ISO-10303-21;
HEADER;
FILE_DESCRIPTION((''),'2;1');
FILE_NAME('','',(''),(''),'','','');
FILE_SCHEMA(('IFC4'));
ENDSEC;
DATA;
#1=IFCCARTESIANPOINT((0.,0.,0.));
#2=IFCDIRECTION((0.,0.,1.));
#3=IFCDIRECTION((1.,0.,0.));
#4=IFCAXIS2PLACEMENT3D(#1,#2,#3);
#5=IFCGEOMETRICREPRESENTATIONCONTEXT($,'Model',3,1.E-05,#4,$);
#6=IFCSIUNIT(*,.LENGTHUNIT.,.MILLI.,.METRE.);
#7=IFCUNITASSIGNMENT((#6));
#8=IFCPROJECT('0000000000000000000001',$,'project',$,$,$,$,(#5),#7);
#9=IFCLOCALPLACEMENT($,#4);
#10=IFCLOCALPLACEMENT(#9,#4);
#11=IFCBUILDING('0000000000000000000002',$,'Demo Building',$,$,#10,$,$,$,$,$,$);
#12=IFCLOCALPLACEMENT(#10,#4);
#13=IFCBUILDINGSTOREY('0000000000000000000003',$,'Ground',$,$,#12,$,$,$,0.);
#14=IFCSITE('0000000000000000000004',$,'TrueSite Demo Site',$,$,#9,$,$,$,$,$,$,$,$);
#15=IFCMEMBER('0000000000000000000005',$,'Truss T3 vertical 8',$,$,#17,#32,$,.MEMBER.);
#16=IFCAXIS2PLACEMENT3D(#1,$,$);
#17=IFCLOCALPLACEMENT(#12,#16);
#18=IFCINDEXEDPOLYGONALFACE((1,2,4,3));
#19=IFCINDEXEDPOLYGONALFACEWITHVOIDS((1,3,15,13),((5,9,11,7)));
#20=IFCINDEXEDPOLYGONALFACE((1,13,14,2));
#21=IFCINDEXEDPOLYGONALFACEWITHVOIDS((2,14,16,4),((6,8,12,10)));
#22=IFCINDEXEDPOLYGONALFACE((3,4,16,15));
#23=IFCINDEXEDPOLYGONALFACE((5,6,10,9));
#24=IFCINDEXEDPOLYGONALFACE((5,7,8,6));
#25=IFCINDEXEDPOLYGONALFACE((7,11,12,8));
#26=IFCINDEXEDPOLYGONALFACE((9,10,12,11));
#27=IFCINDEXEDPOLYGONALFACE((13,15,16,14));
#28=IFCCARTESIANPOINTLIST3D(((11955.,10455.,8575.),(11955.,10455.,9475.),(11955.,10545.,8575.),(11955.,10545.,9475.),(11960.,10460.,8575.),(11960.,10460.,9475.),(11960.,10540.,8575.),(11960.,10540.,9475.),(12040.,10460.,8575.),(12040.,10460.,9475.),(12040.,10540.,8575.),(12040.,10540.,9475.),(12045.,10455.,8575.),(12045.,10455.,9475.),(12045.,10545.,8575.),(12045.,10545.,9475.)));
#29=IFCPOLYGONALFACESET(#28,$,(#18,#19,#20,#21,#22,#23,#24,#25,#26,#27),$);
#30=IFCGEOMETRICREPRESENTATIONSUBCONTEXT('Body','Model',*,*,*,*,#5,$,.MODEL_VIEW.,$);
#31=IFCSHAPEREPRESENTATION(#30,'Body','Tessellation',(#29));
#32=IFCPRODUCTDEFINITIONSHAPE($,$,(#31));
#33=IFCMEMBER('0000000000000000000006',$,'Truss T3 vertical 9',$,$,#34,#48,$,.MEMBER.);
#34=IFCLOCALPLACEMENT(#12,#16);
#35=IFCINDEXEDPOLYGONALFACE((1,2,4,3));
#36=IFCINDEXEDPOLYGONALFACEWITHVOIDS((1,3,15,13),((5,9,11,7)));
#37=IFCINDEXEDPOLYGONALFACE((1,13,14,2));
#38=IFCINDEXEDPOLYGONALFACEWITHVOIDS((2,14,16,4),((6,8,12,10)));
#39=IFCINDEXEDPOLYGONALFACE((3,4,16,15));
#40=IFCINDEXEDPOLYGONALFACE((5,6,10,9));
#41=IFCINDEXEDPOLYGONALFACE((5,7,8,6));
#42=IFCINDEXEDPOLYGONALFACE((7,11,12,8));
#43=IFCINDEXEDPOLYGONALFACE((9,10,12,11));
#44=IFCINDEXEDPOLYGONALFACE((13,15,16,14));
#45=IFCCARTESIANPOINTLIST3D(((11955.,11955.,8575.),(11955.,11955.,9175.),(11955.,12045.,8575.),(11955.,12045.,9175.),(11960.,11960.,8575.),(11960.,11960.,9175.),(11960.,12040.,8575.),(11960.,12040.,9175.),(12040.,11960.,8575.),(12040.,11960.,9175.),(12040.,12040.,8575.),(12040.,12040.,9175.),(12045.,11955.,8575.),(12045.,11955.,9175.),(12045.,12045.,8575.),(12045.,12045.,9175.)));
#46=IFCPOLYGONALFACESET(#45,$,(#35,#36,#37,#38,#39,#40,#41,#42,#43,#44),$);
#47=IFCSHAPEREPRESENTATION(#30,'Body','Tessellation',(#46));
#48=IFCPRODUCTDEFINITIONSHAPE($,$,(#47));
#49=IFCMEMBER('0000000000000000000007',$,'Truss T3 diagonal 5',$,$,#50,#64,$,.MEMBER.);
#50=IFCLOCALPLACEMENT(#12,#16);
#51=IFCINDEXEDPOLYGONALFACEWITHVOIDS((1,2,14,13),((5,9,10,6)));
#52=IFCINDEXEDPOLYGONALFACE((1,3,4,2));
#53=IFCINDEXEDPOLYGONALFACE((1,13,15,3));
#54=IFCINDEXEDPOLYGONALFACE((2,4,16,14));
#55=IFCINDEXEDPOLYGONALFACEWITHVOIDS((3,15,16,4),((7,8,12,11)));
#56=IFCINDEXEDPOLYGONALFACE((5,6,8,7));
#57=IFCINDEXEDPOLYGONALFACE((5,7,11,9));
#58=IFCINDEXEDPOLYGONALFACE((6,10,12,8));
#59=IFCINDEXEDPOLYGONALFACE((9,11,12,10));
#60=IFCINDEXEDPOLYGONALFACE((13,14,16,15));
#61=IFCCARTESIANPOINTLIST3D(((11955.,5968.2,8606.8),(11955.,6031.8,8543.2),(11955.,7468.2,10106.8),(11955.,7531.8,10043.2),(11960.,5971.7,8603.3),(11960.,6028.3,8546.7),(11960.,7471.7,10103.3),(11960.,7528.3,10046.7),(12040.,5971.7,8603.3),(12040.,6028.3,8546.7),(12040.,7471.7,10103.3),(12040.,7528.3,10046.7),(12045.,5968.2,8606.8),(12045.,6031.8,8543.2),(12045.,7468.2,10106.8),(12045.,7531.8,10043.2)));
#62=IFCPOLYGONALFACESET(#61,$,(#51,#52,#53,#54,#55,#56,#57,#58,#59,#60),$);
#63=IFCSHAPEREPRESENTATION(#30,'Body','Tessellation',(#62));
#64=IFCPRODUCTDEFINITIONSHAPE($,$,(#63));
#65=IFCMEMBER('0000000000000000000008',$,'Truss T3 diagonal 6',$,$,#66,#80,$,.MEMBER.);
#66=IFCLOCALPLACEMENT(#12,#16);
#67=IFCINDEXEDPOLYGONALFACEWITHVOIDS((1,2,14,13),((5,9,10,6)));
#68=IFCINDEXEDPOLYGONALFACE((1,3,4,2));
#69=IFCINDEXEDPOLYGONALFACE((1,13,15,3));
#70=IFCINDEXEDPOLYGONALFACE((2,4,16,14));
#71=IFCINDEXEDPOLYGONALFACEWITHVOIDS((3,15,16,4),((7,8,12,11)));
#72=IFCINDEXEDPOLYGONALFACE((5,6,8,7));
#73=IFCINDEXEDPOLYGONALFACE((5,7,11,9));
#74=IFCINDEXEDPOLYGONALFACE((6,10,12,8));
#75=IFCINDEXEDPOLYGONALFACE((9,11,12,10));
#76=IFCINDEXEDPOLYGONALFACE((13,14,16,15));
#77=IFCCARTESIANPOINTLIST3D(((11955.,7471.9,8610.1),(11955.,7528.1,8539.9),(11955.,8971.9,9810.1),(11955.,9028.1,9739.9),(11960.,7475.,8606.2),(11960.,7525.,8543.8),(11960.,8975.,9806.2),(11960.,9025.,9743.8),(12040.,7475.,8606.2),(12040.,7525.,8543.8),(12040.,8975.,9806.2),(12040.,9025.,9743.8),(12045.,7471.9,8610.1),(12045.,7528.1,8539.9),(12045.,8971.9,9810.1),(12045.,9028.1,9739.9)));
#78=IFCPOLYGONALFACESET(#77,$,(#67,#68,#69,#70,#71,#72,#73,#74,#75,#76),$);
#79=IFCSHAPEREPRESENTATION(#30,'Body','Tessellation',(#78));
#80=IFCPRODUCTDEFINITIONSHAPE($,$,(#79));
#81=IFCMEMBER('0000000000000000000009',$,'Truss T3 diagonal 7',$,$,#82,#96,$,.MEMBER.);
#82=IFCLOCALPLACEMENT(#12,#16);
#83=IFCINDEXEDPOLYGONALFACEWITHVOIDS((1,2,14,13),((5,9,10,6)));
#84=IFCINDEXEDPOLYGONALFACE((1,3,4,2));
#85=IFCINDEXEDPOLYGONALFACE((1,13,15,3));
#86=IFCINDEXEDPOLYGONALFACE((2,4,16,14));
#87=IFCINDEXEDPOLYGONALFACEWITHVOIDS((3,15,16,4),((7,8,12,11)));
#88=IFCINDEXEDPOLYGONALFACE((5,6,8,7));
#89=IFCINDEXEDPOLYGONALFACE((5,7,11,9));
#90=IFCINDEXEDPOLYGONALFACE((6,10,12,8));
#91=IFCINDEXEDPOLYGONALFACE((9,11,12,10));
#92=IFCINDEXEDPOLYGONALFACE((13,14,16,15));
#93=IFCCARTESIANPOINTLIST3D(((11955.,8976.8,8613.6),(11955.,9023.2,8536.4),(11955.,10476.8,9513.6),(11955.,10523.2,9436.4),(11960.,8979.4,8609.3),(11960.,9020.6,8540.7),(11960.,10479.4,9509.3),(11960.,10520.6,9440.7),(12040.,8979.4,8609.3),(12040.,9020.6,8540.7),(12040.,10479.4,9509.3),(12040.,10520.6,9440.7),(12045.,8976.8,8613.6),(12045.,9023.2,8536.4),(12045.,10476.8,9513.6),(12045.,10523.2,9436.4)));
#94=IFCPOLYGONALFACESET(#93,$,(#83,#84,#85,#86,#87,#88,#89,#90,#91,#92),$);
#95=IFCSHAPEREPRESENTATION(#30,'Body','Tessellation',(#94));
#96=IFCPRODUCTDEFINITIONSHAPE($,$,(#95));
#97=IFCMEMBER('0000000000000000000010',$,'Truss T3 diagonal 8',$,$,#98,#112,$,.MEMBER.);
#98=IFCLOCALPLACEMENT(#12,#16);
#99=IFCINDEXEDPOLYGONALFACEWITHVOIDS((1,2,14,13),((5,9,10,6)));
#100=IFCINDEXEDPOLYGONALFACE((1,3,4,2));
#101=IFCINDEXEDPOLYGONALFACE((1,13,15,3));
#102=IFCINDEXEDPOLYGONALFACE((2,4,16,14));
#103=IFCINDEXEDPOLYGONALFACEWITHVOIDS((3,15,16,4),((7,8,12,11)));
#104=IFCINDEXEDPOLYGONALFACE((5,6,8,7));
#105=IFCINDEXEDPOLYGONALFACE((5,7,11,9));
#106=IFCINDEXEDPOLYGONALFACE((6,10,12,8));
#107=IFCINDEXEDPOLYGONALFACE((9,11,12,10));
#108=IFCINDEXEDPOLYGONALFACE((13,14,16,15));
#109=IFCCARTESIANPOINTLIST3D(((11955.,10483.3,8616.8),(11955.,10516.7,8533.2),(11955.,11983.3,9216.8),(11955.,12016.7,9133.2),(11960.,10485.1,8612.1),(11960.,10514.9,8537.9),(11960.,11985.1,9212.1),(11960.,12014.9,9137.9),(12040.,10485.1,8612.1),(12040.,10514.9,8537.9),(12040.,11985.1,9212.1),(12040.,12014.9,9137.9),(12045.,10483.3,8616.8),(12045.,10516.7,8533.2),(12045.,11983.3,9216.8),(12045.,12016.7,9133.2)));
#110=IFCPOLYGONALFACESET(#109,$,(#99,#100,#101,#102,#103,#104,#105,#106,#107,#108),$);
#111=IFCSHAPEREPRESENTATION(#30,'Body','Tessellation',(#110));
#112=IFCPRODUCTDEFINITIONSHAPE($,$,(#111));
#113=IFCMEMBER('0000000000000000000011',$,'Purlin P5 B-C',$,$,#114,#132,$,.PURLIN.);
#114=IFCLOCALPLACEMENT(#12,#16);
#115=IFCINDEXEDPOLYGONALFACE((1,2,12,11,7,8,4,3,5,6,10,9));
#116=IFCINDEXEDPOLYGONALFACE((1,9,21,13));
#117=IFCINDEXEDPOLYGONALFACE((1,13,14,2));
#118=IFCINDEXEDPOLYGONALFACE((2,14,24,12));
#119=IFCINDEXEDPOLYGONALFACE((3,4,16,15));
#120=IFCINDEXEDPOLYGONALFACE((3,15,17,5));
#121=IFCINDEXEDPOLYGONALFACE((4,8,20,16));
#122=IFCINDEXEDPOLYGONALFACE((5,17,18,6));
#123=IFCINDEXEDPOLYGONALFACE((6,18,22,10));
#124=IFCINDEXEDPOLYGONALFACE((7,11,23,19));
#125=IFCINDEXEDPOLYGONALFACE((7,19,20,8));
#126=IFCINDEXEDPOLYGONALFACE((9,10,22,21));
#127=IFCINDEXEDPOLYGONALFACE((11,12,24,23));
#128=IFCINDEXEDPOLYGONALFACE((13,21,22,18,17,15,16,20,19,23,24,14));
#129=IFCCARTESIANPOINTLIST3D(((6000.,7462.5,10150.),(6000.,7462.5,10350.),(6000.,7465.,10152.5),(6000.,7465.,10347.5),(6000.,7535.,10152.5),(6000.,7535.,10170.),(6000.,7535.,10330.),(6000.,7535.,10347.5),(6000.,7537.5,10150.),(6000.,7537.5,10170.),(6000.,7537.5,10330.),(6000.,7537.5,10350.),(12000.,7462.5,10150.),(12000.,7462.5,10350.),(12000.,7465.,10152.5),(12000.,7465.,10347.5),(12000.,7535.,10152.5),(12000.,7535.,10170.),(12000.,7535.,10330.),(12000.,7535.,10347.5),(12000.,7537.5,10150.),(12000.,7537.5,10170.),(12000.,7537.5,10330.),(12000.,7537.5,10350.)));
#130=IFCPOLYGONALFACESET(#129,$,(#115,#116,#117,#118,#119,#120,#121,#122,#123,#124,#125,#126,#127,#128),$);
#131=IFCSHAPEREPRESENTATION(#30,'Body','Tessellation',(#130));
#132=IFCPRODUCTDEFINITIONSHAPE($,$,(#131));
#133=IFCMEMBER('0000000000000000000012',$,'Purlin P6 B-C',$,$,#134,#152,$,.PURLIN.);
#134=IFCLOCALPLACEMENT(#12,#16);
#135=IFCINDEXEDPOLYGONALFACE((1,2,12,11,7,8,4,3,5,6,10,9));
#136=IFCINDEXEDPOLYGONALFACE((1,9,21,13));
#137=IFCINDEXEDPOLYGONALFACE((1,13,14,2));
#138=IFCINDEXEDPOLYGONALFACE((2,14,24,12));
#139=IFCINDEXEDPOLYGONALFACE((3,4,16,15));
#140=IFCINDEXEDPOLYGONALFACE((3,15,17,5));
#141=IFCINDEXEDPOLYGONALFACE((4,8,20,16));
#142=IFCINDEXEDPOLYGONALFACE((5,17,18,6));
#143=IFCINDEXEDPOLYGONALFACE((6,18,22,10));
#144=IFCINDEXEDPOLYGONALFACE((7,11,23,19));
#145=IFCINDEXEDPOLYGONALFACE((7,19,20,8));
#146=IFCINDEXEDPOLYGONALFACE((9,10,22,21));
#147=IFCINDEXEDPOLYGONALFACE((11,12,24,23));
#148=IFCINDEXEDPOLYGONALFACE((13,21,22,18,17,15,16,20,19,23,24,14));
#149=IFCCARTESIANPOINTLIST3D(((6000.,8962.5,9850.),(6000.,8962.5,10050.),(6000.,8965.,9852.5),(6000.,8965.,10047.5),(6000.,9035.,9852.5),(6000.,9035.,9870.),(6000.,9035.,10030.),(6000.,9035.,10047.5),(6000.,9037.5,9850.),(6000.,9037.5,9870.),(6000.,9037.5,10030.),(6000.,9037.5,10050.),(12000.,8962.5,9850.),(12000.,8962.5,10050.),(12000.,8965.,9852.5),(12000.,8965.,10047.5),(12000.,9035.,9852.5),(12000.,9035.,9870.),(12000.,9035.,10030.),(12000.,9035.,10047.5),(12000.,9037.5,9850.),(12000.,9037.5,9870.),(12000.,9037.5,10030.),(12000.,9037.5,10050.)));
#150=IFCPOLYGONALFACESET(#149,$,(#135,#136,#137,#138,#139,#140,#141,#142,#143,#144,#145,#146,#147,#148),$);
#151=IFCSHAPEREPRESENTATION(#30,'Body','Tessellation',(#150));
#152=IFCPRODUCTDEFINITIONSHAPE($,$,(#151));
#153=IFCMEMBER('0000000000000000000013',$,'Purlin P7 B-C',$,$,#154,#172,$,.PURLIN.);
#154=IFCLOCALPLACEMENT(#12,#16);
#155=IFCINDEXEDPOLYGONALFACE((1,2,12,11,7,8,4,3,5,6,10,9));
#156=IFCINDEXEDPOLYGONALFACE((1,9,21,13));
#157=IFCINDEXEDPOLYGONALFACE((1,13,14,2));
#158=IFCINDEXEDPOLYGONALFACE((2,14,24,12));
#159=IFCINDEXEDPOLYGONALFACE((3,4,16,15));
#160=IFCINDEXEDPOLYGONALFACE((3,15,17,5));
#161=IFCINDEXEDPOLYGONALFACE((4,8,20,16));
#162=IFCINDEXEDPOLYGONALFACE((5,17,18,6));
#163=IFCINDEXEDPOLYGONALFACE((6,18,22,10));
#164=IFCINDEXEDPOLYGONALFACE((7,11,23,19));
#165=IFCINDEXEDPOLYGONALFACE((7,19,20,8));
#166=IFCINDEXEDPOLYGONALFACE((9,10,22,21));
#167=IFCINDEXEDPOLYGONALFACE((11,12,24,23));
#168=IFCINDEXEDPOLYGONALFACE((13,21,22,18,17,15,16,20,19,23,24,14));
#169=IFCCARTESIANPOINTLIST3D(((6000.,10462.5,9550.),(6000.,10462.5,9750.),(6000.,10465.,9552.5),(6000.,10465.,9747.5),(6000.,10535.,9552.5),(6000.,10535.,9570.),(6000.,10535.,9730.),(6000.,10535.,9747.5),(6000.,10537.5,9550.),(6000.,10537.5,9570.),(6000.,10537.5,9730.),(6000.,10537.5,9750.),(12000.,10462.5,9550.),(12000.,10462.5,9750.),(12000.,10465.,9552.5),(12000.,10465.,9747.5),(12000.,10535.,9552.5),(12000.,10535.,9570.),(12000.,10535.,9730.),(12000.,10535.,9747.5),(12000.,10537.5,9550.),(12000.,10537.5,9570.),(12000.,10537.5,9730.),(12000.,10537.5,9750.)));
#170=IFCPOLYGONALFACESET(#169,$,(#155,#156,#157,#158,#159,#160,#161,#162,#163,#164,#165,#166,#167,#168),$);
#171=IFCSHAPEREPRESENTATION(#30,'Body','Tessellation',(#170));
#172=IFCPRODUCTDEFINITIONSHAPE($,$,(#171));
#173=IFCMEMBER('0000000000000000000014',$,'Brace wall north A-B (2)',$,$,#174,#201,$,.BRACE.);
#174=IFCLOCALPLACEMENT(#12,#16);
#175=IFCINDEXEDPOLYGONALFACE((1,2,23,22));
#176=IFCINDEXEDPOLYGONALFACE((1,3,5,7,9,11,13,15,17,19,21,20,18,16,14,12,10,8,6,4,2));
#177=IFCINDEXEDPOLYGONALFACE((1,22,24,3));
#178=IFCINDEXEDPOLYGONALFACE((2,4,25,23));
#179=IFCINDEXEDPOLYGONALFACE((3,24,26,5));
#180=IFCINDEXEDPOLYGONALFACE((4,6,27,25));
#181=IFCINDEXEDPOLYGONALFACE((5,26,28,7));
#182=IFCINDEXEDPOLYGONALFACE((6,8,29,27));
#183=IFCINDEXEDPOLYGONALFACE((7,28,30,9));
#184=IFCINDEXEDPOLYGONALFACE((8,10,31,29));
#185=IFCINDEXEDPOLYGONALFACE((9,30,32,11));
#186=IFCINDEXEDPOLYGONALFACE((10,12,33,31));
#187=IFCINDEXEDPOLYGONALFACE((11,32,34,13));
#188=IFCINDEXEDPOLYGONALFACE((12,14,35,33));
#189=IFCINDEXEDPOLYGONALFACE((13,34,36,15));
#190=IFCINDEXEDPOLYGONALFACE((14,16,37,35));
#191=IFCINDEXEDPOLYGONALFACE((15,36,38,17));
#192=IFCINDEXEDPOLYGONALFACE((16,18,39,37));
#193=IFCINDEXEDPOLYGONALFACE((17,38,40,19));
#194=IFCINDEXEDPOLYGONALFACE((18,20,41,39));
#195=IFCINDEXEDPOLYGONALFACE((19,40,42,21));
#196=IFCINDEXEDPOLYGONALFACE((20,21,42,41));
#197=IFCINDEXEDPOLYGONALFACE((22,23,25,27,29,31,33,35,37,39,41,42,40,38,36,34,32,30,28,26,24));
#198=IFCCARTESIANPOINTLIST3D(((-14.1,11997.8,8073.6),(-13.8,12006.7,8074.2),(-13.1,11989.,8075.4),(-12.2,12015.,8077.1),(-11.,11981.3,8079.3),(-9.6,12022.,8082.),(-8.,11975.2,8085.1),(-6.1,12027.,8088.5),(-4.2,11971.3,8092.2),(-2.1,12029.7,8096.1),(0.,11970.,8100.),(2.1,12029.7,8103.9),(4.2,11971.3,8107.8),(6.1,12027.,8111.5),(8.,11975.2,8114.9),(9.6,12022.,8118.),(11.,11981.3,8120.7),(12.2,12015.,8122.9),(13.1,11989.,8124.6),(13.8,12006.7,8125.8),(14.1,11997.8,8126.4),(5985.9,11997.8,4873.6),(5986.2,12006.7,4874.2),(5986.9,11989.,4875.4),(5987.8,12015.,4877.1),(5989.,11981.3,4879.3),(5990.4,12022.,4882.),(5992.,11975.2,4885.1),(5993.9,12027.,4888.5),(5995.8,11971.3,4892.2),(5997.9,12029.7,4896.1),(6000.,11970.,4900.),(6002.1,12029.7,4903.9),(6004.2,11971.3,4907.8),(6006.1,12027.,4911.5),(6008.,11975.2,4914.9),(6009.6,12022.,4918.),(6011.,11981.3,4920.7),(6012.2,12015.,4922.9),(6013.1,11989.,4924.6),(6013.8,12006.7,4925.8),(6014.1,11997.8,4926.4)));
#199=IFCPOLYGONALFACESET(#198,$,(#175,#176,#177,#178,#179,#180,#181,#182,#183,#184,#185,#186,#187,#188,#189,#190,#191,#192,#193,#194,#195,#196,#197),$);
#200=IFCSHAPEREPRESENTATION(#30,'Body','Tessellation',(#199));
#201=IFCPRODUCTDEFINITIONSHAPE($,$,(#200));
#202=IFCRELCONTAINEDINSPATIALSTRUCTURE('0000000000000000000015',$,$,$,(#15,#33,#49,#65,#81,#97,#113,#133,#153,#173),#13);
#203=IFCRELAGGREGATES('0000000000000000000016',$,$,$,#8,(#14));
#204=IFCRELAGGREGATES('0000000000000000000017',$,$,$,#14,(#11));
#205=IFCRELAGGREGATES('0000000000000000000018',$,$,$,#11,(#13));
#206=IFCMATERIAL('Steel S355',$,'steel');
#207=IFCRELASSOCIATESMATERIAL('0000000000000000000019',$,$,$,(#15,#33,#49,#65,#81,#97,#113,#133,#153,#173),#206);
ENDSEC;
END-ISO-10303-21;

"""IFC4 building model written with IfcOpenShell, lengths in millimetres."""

from ifc_helpers import new_model, si_unit, frame, origin_with_axes, place, context, subcontext, project, spatial, hollow_rectangle, circle, c_section, extrude, material, element, save


model = new_model("IFC4")

# Units and contexts
model_context = context("Model", 3, precision=1e-05, world=origin_with_axes())
body_context = subcontext(model_context, "Body", "Model", "MODEL_VIEW")
ifc_project = project(units=[si_unit("LENGTHUNIT", "METRE", prefix="MILLI")], contexts=[model_context])

# Site, building, storey
site_placement = place(None, origin_with_axes())
site = spatial("IfcSite", under=ifc_project, at=site_placement, Name="TrueSite Demo Site")
building_placement = place(site_placement, origin_with_axes())
building = spatial("IfcBuilding", under=site, at=building_placement, Name="Demo Building")
storey_placement = place(building_placement, origin_with_axes())
storey = spatial("IfcBuildingStorey", under=building, at=storey_placement, Name="Ground", Elevation=0.0)

# Shared definitions
ifc_material_1 = material(Name="Steel S355", Category="steel")

# Members
member_1_placement = place(storey_placement, frame((12000.0, 10500.0, 8575.0), z_axis=(0.0, 0.0, 1.0), x_axis=(1.0, 0.0, 0.0)))
element("IfcMember", 1, at=member_1_placement, inside=storey, material=ifc_material_1, Name="Truss T3 vertical 8", PredefinedType="MEMBER", context=body_context, shape_type="SweptSolid", body=[
    extrude(hollow_rectangle(XDim=90.0, YDim=90.0, WallThickness=5.0), origin_with_axes(), (0.0, 0.0, 1.0), 900.0),
])
member_2_placement = place(storey_placement, frame((12000.0, 12000.0, 8575.0), z_axis=(0.0, 0.0, 1.0), x_axis=(1.0, 0.0, 0.0)))
element("IfcMember", 2, at=member_2_placement, inside=storey, material=ifc_material_1, Name="Truss T3 vertical 9", PredefinedType="MEMBER", context=body_context, shape_type="SweptSolid", body=[
    extrude(hollow_rectangle(XDim=90.0, YDim=90.0, WallThickness=5.0), origin_with_axes(), (0.0, 0.0, 1.0), 600.0),
])
member_3_placement = place(storey_placement, frame((12000.0, 6000.0, 8575.0), z_axis=(0.0, 0.707107, 0.707107), x_axis=(-1.0, 0.0, 0.0)))
element("IfcMember", 3, at=member_3_placement, inside=storey, material=ifc_material_1, Name="Truss T3 diagonal 5", PredefinedType="MEMBER", context=body_context, shape_type="SweptSolid", body=[
    extrude(hollow_rectangle(XDim=90.0, YDim=90.0, WallThickness=5.0), origin_with_axes(), (0.0, 0.0, 1.0), 2121.3),
])
member_4_placement = place(storey_placement, frame((12000.0, 7500.0, 8575.0), z_axis=(0.0, 0.780869, 0.624695), x_axis=(-1.0, 0.0, 0.0)))
element("IfcMember", 4, at=member_4_placement, inside=storey, material=ifc_material_1, Name="Truss T3 diagonal 6", PredefinedType="MEMBER", context=body_context, shape_type="SweptSolid", body=[
    extrude(hollow_rectangle(XDim=90.0, YDim=90.0, WallThickness=5.0), origin_with_axes(), (0.0, 0.0, 1.0), 1920.9),
])
member_5_placement = place(storey_placement, frame((12000.0, 9000.0, 8575.0), z_axis=(0.0, 0.857493, 0.514496), x_axis=(-1.0, 0.0, 0.0)))
element("IfcMember", 5, at=member_5_placement, inside=storey, material=ifc_material_1, Name="Truss T3 diagonal 7", PredefinedType="MEMBER", context=body_context, shape_type="SweptSolid", body=[
    extrude(hollow_rectangle(XDim=90.0, YDim=90.0, WallThickness=5.0), origin_with_axes(), (0.0, 0.0, 1.0), 1749.3),
])
member_6_placement = place(storey_placement, frame((12000.0, 10500.0, 8575.0), z_axis=(0.0, 0.928477, 0.371391), x_axis=(-1.0, 0.0, 0.0)))
element("IfcMember", 6, at=member_6_placement, inside=storey, material=ifc_material_1, Name="Truss T3 diagonal 8", PredefinedType="MEMBER", context=body_context, shape_type="SweptSolid", body=[
    extrude(hollow_rectangle(XDim=90.0, YDim=90.0, WallThickness=5.0), origin_with_axes(), (0.0, 0.0, 1.0), 1615.5),
])
for number, where, z_axis, x_axis, name in (
    (7, (6000.0, 7500.0, 10250.0), (1.0, 0.0, 0.0), (0.0, 1.0, 0.0), "Purlin P5 B-C"),
    (8, (6000.0, 9000.0, 9950.0), (1.0, 0.0, 0.0), (0.0, 1.0, 0.0), "Purlin P6 B-C"),
    (9, (6000.0, 10500.0, 9650.0), (1.0, 0.0, 0.0), (0.0, 1.0, 0.0), "Purlin P7 B-C"),
):
    element("IfcMember", number, at=place(storey_placement, frame(where, z_axis=z_axis, x_axis=x_axis)), inside=storey, material=ifc_material_1, Name=name, PredefinedType="PURLIN", context=body_context, shape_type="SweptSolid", body=[
        extrude(c_section(Depth=200.0, Width=75.0, WallThickness=2.5, Girth=20.0), origin_with_axes(), (0.0, 0.0, 1.0), 6000.0),
    ])
member_7_placement = place(storey_placement, frame((6000.0, 12000.0, 4900.0), z_axis=(-0.882353, 0.0, 0.470588), x_axis=(0.0, -1.0, 0.0)))
element("IfcMember", 10, at=member_7_placement, inside=storey, material=ifc_material_1, Name="Brace wall north A-B (2)", PredefinedType="BRACE", context=body_context, shape_type="SweptSolid", body=[
    extrude(circle(Radius=30.0), origin_with_axes(), (0.0, 0.0, 1.0), 6800.0),
])

save(model, "model.ifc")
